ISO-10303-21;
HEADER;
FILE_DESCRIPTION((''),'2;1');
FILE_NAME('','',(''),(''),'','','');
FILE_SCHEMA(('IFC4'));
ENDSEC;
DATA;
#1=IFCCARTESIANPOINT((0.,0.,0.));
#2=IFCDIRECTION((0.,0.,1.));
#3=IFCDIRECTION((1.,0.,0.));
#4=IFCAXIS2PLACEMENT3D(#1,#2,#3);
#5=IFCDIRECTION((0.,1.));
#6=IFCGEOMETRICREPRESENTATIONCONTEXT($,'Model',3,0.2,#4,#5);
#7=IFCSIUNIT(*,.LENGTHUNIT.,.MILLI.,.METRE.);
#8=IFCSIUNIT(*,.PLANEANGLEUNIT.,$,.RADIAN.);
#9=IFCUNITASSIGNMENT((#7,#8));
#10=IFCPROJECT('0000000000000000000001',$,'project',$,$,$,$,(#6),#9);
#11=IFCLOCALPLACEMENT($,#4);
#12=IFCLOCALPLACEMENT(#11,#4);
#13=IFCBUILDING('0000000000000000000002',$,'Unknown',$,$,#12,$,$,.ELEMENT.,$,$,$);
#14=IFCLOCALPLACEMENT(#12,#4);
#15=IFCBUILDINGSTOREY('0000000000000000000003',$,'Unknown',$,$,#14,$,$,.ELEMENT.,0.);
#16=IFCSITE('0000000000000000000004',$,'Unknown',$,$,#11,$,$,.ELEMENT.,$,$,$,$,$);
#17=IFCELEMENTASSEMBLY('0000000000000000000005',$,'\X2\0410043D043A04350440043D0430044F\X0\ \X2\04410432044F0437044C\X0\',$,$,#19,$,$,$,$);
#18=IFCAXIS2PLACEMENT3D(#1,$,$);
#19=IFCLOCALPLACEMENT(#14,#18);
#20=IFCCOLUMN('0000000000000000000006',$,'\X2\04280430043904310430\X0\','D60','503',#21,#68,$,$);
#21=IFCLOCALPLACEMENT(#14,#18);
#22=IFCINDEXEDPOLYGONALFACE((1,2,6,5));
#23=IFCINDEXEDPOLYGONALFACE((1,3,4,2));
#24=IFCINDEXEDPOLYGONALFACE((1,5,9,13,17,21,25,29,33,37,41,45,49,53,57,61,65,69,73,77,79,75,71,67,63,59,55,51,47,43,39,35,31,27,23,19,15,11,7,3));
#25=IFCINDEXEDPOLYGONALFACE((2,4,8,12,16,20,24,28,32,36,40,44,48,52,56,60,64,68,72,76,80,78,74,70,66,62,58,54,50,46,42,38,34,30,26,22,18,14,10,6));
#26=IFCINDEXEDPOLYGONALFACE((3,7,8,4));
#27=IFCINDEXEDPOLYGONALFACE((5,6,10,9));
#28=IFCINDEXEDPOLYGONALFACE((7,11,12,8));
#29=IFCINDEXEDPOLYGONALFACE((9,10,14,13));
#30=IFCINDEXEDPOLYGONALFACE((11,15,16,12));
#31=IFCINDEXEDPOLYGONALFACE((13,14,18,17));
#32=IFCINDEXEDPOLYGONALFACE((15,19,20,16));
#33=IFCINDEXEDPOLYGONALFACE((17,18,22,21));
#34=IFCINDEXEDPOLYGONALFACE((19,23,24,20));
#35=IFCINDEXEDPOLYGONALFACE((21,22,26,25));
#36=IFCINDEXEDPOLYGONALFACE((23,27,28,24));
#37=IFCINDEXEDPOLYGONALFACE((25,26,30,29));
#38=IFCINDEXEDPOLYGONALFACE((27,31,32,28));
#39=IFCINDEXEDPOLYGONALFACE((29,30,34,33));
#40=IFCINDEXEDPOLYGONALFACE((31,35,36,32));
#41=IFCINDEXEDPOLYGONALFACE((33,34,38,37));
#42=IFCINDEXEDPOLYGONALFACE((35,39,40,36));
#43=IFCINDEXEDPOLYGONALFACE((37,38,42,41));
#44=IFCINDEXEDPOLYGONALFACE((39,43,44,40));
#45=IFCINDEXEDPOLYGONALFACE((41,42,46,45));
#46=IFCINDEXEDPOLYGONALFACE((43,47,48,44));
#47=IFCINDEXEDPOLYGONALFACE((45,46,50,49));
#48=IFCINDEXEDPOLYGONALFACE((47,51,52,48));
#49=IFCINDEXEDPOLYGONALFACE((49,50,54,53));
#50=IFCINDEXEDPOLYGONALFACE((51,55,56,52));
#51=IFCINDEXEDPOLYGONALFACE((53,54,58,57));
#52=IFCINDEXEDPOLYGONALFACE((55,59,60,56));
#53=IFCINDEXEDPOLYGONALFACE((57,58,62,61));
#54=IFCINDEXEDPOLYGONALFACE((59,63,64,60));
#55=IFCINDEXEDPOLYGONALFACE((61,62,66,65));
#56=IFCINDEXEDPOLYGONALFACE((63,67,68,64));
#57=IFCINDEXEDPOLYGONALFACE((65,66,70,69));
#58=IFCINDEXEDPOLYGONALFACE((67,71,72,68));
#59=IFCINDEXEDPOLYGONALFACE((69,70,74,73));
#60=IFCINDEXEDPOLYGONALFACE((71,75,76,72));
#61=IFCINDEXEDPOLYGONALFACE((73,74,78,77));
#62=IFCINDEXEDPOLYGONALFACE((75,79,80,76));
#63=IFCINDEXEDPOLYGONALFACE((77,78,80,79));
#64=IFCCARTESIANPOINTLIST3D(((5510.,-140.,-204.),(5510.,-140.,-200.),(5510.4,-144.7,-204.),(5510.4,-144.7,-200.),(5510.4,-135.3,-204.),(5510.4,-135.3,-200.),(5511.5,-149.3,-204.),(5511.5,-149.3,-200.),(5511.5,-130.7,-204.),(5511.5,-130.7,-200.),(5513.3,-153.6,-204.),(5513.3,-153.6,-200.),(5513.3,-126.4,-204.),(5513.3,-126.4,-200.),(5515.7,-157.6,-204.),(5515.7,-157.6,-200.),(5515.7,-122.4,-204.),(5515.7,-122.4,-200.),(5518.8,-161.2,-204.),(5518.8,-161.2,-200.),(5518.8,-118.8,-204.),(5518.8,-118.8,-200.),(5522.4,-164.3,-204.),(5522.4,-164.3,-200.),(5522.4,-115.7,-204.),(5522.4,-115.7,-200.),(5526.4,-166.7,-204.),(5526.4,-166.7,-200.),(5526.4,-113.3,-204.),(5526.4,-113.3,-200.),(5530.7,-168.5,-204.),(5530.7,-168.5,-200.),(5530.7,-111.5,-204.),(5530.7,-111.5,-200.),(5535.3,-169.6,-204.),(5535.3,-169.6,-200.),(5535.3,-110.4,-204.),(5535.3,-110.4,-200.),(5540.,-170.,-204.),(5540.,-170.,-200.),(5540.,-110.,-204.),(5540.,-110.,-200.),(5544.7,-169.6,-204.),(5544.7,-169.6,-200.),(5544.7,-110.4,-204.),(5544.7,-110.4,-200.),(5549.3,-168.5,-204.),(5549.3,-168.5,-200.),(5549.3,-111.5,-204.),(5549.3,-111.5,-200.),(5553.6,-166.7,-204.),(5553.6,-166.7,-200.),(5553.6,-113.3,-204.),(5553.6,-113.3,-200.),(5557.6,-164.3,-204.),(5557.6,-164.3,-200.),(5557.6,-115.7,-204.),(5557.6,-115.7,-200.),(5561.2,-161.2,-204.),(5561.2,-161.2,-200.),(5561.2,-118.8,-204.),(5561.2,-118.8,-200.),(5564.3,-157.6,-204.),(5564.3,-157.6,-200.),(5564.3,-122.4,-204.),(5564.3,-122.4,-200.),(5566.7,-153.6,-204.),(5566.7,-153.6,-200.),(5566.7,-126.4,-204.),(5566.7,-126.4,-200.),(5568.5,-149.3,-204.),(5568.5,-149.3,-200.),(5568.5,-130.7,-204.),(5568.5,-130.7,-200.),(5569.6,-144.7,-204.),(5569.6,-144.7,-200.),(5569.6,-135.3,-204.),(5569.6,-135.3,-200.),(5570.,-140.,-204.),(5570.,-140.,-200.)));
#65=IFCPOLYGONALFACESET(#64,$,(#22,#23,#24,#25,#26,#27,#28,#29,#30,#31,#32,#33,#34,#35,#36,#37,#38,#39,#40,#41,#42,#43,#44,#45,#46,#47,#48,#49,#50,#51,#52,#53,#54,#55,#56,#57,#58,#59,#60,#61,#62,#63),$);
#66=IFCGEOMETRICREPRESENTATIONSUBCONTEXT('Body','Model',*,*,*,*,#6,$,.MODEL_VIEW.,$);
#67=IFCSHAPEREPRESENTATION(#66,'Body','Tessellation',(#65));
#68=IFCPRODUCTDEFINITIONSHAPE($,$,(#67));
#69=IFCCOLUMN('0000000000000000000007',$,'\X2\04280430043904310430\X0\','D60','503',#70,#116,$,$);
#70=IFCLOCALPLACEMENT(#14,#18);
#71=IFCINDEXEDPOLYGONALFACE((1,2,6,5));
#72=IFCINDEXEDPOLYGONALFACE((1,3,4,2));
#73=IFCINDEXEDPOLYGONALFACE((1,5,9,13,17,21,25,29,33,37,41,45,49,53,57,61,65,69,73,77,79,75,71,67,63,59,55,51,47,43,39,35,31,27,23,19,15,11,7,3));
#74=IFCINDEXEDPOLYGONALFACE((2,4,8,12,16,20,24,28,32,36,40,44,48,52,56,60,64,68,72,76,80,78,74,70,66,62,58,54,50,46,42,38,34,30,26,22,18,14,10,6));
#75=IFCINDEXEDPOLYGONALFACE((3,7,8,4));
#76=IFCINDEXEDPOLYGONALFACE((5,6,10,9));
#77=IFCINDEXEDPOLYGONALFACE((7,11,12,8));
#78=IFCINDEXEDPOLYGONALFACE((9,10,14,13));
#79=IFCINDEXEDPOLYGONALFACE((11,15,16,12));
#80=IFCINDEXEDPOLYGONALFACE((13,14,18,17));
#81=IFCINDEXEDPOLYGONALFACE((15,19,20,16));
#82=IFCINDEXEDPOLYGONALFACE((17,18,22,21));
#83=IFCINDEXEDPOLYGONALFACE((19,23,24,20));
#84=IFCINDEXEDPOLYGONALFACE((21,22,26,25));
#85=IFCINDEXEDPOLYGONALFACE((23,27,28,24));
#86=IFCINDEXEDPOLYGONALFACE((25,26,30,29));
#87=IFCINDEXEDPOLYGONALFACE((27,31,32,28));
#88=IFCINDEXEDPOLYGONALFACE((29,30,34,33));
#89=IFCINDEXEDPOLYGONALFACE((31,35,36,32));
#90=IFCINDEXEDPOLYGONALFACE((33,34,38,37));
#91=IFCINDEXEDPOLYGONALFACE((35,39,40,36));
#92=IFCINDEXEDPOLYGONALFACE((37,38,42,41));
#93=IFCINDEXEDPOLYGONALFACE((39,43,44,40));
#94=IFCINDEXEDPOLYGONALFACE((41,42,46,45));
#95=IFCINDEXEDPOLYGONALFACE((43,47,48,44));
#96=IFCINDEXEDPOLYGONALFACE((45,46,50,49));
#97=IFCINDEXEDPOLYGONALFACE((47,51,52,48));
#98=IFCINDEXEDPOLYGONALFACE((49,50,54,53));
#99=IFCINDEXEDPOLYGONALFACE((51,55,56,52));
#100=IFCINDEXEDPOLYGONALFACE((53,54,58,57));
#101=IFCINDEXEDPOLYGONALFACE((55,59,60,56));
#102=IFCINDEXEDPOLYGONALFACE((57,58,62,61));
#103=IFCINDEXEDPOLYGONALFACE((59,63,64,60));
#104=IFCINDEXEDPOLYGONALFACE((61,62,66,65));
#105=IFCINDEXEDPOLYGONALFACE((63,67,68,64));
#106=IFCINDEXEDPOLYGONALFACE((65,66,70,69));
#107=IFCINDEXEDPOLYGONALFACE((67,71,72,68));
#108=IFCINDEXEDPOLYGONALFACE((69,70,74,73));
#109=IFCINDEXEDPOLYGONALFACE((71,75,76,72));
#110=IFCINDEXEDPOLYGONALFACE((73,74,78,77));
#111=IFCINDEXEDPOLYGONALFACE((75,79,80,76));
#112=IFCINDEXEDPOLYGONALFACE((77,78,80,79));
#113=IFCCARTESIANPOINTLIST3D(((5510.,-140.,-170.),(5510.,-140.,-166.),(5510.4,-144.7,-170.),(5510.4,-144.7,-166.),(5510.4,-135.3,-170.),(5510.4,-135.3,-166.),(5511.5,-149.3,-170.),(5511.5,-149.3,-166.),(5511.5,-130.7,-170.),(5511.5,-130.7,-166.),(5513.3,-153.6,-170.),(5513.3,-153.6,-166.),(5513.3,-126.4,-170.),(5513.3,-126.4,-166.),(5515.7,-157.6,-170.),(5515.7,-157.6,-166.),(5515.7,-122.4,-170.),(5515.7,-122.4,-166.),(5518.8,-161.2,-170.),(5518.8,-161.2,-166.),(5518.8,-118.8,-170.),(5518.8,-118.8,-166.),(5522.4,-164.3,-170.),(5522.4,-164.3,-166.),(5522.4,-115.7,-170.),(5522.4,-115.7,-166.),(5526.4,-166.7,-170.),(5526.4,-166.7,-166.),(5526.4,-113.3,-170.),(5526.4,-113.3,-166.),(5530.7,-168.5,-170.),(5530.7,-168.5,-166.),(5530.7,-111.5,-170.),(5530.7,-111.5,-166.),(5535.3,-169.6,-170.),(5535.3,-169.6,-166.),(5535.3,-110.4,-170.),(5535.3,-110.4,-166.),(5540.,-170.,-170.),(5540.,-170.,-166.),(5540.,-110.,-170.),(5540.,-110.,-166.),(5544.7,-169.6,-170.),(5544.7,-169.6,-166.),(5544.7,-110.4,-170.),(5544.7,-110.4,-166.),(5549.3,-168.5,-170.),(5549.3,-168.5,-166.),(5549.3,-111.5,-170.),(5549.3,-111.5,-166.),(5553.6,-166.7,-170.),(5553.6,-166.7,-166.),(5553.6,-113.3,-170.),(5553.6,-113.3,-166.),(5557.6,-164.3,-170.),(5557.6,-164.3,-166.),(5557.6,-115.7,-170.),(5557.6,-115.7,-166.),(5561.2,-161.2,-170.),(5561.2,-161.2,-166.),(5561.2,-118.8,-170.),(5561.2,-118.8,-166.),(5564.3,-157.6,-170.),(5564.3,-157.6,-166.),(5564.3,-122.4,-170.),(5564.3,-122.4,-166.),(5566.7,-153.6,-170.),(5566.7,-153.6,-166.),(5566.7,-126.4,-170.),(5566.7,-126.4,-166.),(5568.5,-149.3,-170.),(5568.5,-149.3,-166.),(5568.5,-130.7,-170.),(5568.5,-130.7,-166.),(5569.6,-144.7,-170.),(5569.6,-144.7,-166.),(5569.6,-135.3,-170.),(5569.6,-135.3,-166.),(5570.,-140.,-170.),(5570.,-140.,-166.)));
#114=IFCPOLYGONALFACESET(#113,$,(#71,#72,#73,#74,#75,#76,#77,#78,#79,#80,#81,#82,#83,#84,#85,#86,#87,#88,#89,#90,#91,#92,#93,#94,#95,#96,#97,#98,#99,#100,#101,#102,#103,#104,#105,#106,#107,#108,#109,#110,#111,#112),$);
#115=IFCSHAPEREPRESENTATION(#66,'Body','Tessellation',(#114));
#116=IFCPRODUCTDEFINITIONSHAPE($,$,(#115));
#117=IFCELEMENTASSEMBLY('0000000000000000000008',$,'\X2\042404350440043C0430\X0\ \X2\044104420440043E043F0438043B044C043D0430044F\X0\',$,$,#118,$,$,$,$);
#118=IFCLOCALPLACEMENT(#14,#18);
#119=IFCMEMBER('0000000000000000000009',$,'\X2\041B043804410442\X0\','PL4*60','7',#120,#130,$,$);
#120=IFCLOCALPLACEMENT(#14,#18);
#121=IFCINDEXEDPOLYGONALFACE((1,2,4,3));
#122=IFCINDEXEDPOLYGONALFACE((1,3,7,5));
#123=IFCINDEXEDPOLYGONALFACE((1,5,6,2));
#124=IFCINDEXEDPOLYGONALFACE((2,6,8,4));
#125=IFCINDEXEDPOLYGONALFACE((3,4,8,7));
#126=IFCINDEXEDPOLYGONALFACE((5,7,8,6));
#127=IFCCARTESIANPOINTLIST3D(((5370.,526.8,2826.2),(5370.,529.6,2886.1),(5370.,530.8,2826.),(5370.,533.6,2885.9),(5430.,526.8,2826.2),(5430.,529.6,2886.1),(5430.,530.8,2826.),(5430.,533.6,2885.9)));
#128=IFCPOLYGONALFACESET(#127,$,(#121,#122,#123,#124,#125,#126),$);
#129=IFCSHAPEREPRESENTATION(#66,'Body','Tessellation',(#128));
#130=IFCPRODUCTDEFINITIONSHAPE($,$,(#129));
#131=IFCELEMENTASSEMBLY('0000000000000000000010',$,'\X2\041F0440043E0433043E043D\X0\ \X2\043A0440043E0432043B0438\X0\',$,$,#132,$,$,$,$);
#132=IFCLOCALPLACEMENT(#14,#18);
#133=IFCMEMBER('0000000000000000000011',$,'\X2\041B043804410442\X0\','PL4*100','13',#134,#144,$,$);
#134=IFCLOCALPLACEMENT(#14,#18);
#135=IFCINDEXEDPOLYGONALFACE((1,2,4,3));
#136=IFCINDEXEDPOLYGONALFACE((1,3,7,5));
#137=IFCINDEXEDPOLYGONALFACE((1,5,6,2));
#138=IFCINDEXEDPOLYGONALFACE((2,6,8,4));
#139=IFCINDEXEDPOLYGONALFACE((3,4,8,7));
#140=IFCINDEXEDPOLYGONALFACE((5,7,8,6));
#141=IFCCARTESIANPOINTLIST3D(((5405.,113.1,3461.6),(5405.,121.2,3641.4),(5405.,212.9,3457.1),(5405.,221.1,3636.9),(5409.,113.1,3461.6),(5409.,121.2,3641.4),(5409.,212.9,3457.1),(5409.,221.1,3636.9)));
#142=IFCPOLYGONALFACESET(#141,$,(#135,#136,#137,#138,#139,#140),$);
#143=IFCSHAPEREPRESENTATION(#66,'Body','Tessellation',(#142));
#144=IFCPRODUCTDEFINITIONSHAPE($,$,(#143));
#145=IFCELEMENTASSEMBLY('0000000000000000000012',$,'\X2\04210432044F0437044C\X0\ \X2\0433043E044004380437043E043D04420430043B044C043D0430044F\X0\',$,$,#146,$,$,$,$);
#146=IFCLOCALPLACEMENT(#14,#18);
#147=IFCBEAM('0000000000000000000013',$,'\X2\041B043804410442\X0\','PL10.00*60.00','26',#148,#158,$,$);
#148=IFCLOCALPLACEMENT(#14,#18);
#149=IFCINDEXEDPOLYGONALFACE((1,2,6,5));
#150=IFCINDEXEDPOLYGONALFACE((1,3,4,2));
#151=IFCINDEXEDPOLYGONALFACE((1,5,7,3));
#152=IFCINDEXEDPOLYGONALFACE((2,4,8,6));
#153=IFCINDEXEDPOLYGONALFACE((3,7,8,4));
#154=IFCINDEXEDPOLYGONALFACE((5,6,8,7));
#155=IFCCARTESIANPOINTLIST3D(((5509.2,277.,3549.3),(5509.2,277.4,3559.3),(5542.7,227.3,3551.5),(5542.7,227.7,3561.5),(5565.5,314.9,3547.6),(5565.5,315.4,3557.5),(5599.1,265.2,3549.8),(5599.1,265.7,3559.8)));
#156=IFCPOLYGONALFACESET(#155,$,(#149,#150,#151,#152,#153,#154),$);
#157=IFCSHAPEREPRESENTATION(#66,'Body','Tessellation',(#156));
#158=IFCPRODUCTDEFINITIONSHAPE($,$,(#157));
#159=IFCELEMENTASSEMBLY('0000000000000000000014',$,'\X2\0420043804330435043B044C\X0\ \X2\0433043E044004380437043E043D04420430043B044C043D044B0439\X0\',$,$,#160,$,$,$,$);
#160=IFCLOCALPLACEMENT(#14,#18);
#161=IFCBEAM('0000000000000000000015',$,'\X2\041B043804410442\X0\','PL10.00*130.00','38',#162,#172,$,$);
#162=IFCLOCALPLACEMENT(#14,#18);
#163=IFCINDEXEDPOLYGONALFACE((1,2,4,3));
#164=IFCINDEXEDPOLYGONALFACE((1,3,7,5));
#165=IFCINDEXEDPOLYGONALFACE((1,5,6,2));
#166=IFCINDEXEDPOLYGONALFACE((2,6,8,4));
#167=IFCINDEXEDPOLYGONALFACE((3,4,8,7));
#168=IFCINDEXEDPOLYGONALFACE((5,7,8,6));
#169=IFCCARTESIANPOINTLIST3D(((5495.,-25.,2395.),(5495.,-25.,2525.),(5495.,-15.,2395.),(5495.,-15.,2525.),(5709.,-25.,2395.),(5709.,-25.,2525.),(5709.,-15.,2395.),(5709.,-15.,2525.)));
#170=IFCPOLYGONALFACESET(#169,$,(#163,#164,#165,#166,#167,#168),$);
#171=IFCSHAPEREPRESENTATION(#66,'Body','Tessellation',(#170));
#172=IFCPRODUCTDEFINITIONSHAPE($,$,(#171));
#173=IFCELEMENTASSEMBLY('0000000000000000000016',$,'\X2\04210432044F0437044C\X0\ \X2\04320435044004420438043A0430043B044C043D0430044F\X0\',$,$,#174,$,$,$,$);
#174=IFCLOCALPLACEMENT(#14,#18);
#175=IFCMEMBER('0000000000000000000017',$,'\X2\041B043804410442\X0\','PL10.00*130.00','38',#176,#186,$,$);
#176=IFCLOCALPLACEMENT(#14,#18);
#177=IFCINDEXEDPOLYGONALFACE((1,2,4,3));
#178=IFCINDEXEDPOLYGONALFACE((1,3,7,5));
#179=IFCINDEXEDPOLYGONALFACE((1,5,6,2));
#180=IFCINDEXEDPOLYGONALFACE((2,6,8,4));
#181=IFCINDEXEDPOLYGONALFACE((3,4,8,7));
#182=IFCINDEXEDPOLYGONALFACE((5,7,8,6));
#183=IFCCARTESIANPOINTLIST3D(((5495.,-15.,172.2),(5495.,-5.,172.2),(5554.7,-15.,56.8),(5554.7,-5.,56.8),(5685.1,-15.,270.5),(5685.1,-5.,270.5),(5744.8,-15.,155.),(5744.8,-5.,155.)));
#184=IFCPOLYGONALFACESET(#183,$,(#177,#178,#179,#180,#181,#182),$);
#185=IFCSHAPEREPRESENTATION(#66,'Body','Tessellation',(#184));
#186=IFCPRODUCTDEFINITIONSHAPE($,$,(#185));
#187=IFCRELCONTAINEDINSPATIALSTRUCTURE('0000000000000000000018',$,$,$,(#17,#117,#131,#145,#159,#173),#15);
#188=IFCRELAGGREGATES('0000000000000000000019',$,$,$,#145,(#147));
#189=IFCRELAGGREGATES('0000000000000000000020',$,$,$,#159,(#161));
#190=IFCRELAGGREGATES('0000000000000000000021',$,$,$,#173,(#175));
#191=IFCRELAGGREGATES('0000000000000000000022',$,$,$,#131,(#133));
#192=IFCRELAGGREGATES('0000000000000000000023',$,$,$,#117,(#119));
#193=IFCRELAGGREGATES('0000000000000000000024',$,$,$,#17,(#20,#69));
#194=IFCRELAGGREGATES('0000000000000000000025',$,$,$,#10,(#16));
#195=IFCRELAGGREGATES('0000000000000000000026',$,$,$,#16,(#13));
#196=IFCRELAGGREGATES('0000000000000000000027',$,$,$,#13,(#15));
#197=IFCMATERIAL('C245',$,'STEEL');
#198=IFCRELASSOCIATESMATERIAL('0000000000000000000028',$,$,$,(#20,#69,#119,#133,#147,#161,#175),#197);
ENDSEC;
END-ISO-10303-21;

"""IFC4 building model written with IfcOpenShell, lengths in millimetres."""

from ifc_helpers import new_model, si_unit, direction, frame, origin_with_axes, place, context, subcontext, project, spatial, line, indexed_curve, outline, extrude, material, element, aggregate, save


model = new_model("IFC4")

# Units and contexts
model_context = context("Model", 3, precision=0.2, world=origin_with_axes(), true_north=direction((0.0, 1.0)))
body_context = subcontext(model_context, "Body", "Model", "MODEL_VIEW")
ifc_project = project(units=[si_unit("LENGTHUNIT", "METRE", prefix="MILLI"), si_unit("PLANEANGLEUNIT", "RADIAN")], contexts=[model_context])

# Site, building, storey
site_placement = place(None, origin_with_axes())
site = spatial("IfcSite", under=ifc_project, at=site_placement, Name="Unknown", CompositionType="ELEMENT")
building_placement = place(site_placement, origin_with_axes())
building = spatial("IfcBuilding", under=site, at=building_placement, Name="Unknown", CompositionType="ELEMENT")
storey_placement = place(building_placement, origin_with_axes())
storey = spatial("IfcBuildingStorey", under=building, at=storey_placement, Name="Unknown", CompositionType="ELEMENT", Elevation=0.0)

# Element assembly, columns
ifc_material_1 = material(Name="C245", Category="STEEL")
assembly_1_placement = place(storey_placement, frame((5540.0, -140.0, -125.0), z_axis=(1.0, 0.0, 0.0), x_axis=(0.0, 0.0, -1.0)))
assembly_1 = element("IfcElementAssembly", 1, at=assembly_1_placement, inside=storey, Name="Анкерная связь")
column_1_placement = place(assembly_1_placement, frame((75.0, 0.0, 0.0), z_axis=(0.0, 1.0, 0.0), x_axis=(1.0, 0.0, 0.0)))
column_1 = element("IfcColumn", 2, at=column_1_placement, material=ifc_material_1, Name="Шайба", Description="D60", ObjectType="503", context=body_context, shape_type="SolidModel", body=[
    extrude(outline(indexed_curve([(30.0, 0.0), (29.6, 4.7), (28.5, 9.3), (26.7, 13.6), (24.3, 17.6), (21.2, 21.2), (17.6, 24.3), (13.6, 26.7), (9.3, 28.5), (4.7, 29.6), (0.0, 30.0), (-4.7, 29.6), (-9.3, 28.5), (-13.6, 26.7), (-17.6, 24.3), (-21.2, 21.2), (-24.3, 17.6), (-26.7, 13.6), (-28.5, 9.3), (-29.6, 4.7), (-30.0, 0.0), (-29.6, -4.7), (-28.5, -9.3), (-26.7, -13.6), (-24.3, -17.6), (-21.2, -21.2), (-17.6, -24.3), (-13.6, -26.7), (-9.3, -28.5), (-4.7, -29.6), (0.0, -30.0), (4.7, -29.6), (9.3, -28.5), (13.6, -26.7), (17.6, -24.3), (21.2, -21.2), (24.3, -17.6), (26.7, -13.6), (28.5, -9.3), (29.6, -4.7)], segments=[line(1, 2, 3, 4, 5, 6, 7, 8, 9, 10, 11, 12, 13, 14, 15, 16, 17, 18, 19, 20, 21, 22, 23, 24, 25, 26, 27, 28, 29, 30, 31, 32, 33, 34, 35, 36, 37, 38, 39, 40, 1)])), frame((0.0, 0.0, 0.0), z_axis=(-1.0, 0.0, 0.0), x_axis=(0.0, 0.0, 1.0)), (0.0, 0.0, -1.0), 4.0),
])
column_2_placement = place(assembly_1_placement, frame((41.0, 0.0, 0.0), z_axis=(0.0, 0.0, 1.0), x_axis=(1.0, 0.0, 0.0)))
column_2 = element("IfcColumn", 3, at=column_2_placement, material=ifc_material_1, Name="Шайба", Description="D60", ObjectType="503", context=body_context, shape_type="SolidModel", body=[
    extrude(outline(indexed_curve([(30.0, 0.0), (29.6, 4.7), (28.5, 9.3), (26.7, 13.6), (24.3, 17.6), (21.2, 21.2), (17.6, 24.3), (13.6, 26.7), (9.3, 28.5), (4.7, 29.6), (0.0, 30.0), (-4.7, 29.6), (-9.3, 28.5), (-13.6, 26.7), (-17.6, 24.3), (-21.2, 21.2), (-24.3, 17.6), (-26.7, 13.6), (-28.5, 9.3), (-29.6, 4.7), (-30.0, 0.0), (-29.6, -4.7), (-28.5, -9.3), (-26.7, -13.6), (-24.3, -17.6), (-21.2, -21.2), (-17.6, -24.3), (-13.6, -26.7), (-9.3, -28.5), (-4.7, -29.6), (0.0, -30.0), (4.7, -29.6), (9.3, -28.5), (13.6, -26.7), (17.6, -24.3), (21.2, -21.2), (24.3, -17.6), (26.7, -13.6), (28.5, -9.3), (29.6, -4.7)], segments=[line(1, 2, 3, 4, 5, 6, 7, 8, 9, 10, 11, 12, 13, 14, 15, 16, 17, 18, 19, 20, 21, 22, 23, 24, 25, 26, 27, 28, 29, 30, 31, 32, 33, 34, 35, 36, 37, 38, 39, 40, 1)])), frame((0.0, 0.0, 0.0), z_axis=(-1.0, 0.0, 0.0), x_axis=(0.0, 0.0, 1.0)), (0.0, 0.0, -1.0), 4.0),
])

# Element assemblies, members
assembly_2_placement = place(storey_placement, frame((5400.0, 88.6, 3426.7), z_axis=(1.0, 0.0, 0.0), x_axis=(0.0, 0.998969, -0.045408)))
assembly_2 = element("IfcElementAssembly", 4, at=assembly_2_placement, inside=storey, Name="Ферма стропильная")
member_1_placement = place(assembly_2_placement, frame((467.0, -580.0, 0.0), z_axis=(1.0, 0.0, 0.0), x_axis=(0.0, 1.0, 0.0)))
member_1 = element("IfcMember", 5, at=member_1_placement, material=ifc_material_1, Name="Лист", Description="PL4*60", ObjectType="7", context=body_context, shape_type="SolidModel", body=[
    extrude(outline(indexed_curve([(-2.0, -30.0), (2.0, -30.0), (2.0, 30.0), (-2.0, 30.0)], segments=[line(1, 2, 3, 4, 1)])), frame((0.0, 0.0, 0.0), z_axis=(-1.0, 0.0, 0.0), x_axis=(0.0, 0.0, 1.0)), (0.0, 0.0, -1.0), 60.0),
])
assembly_3_placement = place(storey_placement, frame((5405.0, 167.1, 3549.3), z_axis=(0.0, -0.998969, 0.045408), x_axis=(1.0, 0.0, 0.0)))
assembly_3 = element("IfcElementAssembly", 6, at=assembly_3_placement, inside=storey, Name="Прогон кровли")
member_2_placement = place(assembly_3_placement, frame((2.0, -90.0, 0.0), z_axis=(1.0, 0.0, 0.0), x_axis=(0.0, 1.0, 0.0)))
member_2 = element("IfcMember", 7, at=member_2_placement, material=ifc_material_1, Name="Лист", Description="PL4*100", ObjectType="13", context=body_context, shape_type="SolidModel", body=[
    extrude(outline(indexed_curve([(-2.0, -50.0), (2.0, -50.0), (2.0, 50.0), (-2.0, 50.0)], segments=[line(1, 2, 3, 4, 1)])), frame((0.0, 0.0, 0.0), z_axis=(-1.0, 0.0, 0.0), x_axis=(0.0, 0.0, 1.0)), (0.0, 0.0, -1.0), 180.0),
])

# Element assemblies, beams
assembly_4_placement = place(storey_placement, frame((5400.0, 167.5, 3559.3), z_axis=(0.558918, -0.828367, 0.037653), x_axis=(0.829223, 0.558342, -0.025379)))
assembly_4 = element("IfcElementAssembly", 8, at=assembly_4_placement, inside=storey, Name="Связь горизонтальная")
beam_1_placement = place(assembly_4_placement, frame((151.9, 0.0, 0.0), z_axis=(0.0, -1.0, 0.0), x_axis=(1.0, 0.0, 0.0)))
beam_1 = element("IfcBeam", 9, at=beam_1_placement, material=ifc_material_1, Name="Лист", Description="PL10.00*60.00", ObjectType="26", context=body_context, shape_type="SolidModel", body=[
    extrude(outline(indexed_curve([(-5.0, -30.0), (5.0, -30.0), (5.0, 30.0), (-5.0, 30.0)], segments=[line(1, 2, 3, 4, 1)])), frame((0.0, 0.0, 0.0), z_axis=(-1.0, 0.0, 0.0), x_axis=(0.0, 0.0, 1.0)), (0.0, 0.0, -1.0), 68.0),
])
aggregate(assembly_4, [beam_1])
assembly_5_placement = place(storey_placement, frame((11290.0, -20.0, 2460.0), z_axis=(0.0, 1.0, 0.0), x_axis=(-1.0, 0.0, 0.0)))
assembly_5 = element("IfcElementAssembly", 10, at=assembly_5_placement, inside=storey, Name="Ригель горизонтальный")
beam_2_placement = place(assembly_5_placement, frame((5795.0, 0.0, 0.0), z_axis=(0.0, 0.0, -1.0), x_axis=(-1.0, 0.0, 0.0)))
beam_2 = element("IfcBeam", 11, at=beam_2_placement, material=ifc_material_1, Name="Лист", Description="PL10.00*130.00", ObjectType="38", context=body_context, shape_type="SolidModel", body=[
    extrude(outline(indexed_curve([(-5.0, -65.0), (5.0, -65.0), (5.0, 65.0), (-5.0, 65.0)], segments=[line(1, 2, 3, 4, 1)])), frame((0.0, 0.0, 0.0), z_axis=(-1.0, 0.0, 0.0), x_axis=(0.0, 0.0, 1.0)), (0.0, 0.0, -1.0), 214.0),
])
aggregate(assembly_5, [beam_2])

# Element assembly, member
assembly_6_placement = place(storey_placement, frame((5400.0, -10.0, 50.0), z_axis=(0.0, -1.0, 0.0), x_axis=(0.888426, 0.0, 0.45902)))
assembly_6 = element("IfcElementAssembly", 12, at=assembly_6_placement, inside=storey, Name="Связь вертикальная")
member_3_placement = place(assembly_6_placement, frame((140.5, 0.0, 0.0), z_axis=(0.0, 0.0, 1.0), x_axis=(1.0, 0.0, 0.0)))
member_3 = element("IfcMember", 13, at=member_3_placement, material=ifc_material_1, Name="Лист", Description="PL10.00*130.00", ObjectType="38", context=body_context, shape_type="SolidModel", body=[
    extrude(outline(indexed_curve([(-5.0, -65.0), (5.0, -65.0), (5.0, 65.0), (-5.0, 65.0)], segments=[line(1, 2, 3, 4, 1)])), frame((0.0, 0.0, 0.0), z_axis=(-1.0, 0.0, 0.0), x_axis=(0.0, 0.0, 1.0)), (0.0, 0.0, -1.0), 214.0),
])
aggregate(assembly_6, [member_3])

aggregate(assembly_3, [member_2])

aggregate(assembly_2, [member_1])
aggregate(assembly_1, [column_1, column_2])

save(model, "model.ifc")
